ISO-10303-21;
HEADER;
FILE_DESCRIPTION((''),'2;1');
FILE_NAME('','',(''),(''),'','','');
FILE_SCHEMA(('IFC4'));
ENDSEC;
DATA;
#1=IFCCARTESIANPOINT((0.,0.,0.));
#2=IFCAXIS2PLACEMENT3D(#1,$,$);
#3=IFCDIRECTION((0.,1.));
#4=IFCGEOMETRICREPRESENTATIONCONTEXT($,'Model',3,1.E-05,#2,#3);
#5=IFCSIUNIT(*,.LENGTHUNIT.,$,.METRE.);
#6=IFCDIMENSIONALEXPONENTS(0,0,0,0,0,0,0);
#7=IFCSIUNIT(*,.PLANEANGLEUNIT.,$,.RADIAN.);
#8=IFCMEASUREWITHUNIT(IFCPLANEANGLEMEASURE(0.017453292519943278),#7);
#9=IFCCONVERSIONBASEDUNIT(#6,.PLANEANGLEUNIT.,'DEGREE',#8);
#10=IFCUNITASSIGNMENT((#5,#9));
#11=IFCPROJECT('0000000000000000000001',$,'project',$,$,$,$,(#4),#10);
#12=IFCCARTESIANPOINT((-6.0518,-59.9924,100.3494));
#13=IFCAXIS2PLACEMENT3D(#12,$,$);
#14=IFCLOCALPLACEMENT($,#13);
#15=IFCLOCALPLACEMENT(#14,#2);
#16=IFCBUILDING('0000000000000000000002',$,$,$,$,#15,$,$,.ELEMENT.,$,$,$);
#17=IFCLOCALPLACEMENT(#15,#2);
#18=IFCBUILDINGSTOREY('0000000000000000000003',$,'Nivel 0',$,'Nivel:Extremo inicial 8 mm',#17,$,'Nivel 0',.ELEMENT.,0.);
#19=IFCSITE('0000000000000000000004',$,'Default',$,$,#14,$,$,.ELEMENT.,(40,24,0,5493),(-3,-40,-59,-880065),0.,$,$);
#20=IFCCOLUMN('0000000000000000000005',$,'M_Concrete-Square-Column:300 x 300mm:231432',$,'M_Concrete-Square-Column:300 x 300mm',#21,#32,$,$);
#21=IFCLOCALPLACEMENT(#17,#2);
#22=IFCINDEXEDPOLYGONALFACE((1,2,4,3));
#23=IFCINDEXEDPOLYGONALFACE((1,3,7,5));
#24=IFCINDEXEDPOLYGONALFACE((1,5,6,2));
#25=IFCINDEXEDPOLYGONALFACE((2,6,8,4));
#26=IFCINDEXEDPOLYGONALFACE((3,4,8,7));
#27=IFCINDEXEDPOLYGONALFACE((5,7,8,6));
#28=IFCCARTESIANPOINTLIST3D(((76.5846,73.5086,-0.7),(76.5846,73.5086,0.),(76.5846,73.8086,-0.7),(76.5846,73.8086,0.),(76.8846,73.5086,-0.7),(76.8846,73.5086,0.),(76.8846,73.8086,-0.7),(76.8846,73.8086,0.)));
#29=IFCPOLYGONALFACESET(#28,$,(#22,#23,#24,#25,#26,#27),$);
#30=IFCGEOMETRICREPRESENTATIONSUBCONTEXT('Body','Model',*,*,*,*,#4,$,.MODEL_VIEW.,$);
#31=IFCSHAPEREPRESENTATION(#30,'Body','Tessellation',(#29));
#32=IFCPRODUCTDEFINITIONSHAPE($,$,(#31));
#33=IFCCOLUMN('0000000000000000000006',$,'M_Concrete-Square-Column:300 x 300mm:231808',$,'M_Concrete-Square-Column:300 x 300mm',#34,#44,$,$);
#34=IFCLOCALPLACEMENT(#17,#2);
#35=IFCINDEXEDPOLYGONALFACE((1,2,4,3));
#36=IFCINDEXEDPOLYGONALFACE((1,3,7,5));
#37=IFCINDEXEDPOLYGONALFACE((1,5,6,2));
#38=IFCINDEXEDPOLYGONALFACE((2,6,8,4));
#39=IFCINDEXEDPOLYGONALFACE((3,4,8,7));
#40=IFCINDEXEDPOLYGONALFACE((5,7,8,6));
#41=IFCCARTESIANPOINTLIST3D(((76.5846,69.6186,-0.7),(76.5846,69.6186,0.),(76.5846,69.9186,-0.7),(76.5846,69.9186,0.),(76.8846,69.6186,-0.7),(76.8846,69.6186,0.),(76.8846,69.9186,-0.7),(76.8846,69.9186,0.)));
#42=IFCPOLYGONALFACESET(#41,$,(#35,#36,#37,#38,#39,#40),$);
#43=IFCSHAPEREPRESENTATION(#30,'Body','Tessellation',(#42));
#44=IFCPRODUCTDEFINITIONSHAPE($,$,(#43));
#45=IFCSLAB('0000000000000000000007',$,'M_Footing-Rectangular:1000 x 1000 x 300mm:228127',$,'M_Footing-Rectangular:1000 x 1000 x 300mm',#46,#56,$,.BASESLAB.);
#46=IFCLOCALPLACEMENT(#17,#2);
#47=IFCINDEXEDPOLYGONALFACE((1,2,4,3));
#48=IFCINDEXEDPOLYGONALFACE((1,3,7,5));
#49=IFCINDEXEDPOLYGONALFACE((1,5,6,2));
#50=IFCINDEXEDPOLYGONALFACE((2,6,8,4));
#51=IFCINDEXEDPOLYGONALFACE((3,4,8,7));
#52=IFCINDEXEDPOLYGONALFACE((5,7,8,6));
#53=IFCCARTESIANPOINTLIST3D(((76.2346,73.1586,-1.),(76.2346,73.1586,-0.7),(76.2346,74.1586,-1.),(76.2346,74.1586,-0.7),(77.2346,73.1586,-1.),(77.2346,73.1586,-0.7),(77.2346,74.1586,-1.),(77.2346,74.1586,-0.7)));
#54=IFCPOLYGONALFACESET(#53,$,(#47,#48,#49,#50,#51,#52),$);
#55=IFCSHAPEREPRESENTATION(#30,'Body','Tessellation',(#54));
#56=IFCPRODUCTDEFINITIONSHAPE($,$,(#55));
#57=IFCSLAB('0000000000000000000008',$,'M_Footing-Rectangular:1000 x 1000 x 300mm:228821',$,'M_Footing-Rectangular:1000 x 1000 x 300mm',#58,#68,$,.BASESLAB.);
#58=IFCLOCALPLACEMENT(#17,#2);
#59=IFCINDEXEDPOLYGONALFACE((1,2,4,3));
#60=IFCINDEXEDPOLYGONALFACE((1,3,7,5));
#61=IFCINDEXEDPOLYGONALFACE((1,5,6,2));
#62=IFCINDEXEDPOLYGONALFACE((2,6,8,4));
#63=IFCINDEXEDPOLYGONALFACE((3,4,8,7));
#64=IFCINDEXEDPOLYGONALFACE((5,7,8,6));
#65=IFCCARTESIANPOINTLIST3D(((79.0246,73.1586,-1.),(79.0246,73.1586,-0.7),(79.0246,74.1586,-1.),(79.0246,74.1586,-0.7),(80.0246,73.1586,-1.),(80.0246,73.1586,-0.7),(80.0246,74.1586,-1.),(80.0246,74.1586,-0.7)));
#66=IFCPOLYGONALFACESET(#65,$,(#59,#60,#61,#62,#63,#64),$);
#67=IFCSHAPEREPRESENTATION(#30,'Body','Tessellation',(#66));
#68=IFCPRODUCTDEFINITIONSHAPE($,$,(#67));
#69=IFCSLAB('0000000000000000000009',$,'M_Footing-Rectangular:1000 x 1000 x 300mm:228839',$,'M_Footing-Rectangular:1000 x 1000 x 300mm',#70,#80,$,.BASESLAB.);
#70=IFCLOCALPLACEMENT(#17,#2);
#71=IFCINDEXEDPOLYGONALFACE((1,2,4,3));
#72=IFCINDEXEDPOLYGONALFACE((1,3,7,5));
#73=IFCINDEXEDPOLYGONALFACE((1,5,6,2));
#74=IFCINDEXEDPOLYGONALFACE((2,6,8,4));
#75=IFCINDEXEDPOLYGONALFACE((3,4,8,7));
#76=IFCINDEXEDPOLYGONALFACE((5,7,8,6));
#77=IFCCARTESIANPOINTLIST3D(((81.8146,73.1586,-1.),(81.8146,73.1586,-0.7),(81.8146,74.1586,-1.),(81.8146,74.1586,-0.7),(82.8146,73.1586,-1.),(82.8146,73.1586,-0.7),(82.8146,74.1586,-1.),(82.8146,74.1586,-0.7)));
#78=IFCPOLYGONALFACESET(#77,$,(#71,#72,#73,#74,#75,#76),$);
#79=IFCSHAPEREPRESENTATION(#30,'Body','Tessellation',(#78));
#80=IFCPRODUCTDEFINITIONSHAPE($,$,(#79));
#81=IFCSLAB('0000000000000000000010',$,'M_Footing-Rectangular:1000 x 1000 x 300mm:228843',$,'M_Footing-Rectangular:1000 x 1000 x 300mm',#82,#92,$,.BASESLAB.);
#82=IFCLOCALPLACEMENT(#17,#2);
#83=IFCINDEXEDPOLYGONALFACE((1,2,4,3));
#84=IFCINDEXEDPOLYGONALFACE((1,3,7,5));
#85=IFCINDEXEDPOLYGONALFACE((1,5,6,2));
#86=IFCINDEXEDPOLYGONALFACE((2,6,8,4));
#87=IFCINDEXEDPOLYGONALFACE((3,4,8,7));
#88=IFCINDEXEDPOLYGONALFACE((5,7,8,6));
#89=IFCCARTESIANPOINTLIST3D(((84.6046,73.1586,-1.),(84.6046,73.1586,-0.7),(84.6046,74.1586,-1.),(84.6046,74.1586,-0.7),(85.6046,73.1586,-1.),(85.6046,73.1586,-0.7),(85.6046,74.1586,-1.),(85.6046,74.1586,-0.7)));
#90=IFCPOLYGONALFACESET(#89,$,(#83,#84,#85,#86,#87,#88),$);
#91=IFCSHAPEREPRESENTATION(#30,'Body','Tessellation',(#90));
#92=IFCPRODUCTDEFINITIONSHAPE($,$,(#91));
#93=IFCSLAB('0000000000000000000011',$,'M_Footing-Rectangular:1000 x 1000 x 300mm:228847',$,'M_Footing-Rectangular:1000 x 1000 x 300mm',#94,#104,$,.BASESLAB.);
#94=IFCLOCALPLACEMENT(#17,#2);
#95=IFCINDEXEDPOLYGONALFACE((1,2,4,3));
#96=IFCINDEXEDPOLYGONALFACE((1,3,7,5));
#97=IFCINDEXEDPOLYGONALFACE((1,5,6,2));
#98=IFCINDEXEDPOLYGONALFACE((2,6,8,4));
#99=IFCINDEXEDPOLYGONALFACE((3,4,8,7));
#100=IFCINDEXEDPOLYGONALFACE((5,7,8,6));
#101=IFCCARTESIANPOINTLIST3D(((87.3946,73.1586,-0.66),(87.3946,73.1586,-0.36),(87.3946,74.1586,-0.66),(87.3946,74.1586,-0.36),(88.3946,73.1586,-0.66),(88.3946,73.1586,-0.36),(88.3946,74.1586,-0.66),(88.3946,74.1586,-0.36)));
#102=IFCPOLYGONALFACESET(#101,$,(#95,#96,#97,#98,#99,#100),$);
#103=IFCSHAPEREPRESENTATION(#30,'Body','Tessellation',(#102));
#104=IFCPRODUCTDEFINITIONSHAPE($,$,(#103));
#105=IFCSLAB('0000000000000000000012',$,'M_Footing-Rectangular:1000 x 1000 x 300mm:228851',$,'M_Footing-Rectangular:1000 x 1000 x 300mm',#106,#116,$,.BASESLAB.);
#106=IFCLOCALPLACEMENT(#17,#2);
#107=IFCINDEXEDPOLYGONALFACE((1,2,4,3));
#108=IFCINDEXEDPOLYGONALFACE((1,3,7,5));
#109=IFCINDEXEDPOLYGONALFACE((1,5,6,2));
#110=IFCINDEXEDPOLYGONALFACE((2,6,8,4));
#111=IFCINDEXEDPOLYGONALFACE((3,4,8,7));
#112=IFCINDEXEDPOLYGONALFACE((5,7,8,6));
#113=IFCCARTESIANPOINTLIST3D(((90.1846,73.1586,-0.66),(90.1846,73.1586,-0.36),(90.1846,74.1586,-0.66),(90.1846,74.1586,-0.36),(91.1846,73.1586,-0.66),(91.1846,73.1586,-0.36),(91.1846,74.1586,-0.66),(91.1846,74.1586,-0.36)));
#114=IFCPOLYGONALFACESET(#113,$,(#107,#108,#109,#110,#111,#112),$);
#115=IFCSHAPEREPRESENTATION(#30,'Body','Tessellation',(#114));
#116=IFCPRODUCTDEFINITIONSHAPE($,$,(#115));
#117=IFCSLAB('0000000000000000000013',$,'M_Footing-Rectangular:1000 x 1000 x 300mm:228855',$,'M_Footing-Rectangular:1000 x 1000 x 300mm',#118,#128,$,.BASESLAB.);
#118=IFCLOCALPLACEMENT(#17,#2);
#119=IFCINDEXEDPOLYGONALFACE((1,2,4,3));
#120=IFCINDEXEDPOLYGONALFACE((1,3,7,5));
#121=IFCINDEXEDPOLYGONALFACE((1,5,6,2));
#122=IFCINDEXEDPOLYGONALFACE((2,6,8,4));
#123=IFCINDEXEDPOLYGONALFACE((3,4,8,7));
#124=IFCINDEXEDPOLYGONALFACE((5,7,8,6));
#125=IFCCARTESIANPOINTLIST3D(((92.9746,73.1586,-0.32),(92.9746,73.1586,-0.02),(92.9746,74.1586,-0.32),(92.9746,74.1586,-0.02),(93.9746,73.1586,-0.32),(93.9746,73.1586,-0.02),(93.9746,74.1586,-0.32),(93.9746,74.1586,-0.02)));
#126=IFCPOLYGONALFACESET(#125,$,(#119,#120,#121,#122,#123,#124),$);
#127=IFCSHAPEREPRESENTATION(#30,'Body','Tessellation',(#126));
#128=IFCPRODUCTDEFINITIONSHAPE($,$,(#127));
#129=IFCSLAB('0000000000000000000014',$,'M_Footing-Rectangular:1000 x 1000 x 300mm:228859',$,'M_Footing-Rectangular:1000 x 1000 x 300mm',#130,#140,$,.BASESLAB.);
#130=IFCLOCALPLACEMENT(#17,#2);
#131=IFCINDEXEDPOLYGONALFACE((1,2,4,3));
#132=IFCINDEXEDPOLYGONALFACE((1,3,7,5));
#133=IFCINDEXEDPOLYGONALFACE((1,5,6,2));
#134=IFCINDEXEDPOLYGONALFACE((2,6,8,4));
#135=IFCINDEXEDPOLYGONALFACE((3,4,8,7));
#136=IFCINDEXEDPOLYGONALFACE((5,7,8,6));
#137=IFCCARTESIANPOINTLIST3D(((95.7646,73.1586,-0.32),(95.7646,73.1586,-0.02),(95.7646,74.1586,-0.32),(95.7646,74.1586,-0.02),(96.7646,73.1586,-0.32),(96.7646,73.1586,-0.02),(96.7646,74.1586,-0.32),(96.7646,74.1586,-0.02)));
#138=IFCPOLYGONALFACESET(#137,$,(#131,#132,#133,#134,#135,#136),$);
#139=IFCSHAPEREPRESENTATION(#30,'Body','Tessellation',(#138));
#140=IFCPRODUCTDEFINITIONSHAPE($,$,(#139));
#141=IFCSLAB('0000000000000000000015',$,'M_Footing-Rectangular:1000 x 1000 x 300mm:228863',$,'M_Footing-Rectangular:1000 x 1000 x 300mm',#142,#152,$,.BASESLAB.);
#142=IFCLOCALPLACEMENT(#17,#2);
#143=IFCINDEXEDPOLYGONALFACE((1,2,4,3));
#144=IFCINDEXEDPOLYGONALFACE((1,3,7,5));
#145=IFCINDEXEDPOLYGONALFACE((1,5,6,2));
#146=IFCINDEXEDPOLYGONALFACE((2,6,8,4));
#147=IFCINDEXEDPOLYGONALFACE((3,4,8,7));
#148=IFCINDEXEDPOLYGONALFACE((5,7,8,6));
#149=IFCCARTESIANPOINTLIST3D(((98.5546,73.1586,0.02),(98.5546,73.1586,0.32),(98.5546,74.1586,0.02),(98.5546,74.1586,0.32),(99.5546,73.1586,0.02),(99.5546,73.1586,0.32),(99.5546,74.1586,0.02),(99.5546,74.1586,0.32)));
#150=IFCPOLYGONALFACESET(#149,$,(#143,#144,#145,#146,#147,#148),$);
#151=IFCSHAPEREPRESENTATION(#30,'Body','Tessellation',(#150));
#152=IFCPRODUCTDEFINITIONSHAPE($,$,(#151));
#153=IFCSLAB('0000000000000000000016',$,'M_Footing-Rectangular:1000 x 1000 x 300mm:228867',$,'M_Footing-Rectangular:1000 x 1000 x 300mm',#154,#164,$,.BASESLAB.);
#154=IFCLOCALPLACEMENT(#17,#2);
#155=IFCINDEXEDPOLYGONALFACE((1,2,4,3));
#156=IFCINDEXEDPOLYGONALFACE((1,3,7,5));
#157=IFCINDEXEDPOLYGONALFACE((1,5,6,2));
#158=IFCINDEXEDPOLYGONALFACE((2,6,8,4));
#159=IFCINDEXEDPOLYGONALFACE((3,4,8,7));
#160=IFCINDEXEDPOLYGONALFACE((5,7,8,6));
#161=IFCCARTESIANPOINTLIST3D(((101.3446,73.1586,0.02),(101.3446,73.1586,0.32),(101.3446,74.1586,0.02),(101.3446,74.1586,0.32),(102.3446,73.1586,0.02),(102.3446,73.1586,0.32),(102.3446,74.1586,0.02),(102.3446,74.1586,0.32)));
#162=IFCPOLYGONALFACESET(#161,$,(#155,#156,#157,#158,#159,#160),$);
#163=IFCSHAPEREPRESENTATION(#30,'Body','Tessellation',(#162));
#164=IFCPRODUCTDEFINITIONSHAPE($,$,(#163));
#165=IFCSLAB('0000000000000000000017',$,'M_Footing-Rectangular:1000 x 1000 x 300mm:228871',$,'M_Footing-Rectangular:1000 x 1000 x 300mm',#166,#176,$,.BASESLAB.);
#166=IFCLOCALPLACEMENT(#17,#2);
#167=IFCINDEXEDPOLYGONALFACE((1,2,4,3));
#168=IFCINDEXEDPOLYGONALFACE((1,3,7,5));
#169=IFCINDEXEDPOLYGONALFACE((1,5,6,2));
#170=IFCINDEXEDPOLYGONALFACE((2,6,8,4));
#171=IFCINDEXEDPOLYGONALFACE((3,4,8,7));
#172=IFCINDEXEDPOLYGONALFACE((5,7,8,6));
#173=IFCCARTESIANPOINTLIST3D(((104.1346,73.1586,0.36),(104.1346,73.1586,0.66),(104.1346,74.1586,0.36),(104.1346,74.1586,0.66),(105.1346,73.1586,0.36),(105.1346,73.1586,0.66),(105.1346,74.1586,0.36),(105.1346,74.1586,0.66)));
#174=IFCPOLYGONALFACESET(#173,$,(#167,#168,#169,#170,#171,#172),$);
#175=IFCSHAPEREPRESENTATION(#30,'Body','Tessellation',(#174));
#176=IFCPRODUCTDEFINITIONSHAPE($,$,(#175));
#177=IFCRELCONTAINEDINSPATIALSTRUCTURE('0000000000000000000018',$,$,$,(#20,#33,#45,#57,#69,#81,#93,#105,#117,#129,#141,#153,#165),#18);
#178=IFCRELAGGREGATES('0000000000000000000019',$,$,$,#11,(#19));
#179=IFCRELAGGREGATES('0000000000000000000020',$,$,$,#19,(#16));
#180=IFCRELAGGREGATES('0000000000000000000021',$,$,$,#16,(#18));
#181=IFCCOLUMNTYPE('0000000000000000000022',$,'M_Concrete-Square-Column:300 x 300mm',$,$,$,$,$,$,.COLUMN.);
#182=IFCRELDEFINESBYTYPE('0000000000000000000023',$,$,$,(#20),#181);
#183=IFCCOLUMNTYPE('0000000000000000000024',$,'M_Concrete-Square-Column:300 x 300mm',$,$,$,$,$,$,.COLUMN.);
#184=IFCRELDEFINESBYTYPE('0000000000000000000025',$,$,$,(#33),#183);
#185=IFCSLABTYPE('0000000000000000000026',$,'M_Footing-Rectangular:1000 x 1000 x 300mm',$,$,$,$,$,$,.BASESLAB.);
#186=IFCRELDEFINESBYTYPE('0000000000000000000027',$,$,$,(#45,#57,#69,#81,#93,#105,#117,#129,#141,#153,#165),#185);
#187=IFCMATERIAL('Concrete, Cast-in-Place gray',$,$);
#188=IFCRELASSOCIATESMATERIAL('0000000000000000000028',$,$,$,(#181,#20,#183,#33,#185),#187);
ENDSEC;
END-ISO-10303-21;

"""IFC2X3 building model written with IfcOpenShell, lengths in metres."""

from ifc_helpers import new_model, entity, si_unit, converted_unit, direction, frame, frame_2d, origin, origin_2d_with_axis, place, context, subcontext, project, spatial, rectangle, extrude, source, transform, mapped, material, type_object, type_shapes, element, save


model = new_model("IFC2X3")

# Units and contexts
model_context = context("Model", 3, precision=1e-05, world=origin(), true_north=direction((0.0, 1.0)))
body_context = subcontext(model_context, "Body", "Model", "MODEL_VIEW")
ifc_project = project(units=[si_unit("LENGTHUNIT", "METRE"), converted_unit("PLANEANGLEUNIT", "DEGREE", entity("IfcPlaneAngleMeasure", 0.017453292519943278), si_unit("PLANEANGLEUNIT", "RADIAN"), dimensions=[0, 0, 0, 0, 0, 0, 0])], contexts=[model_context])

# Site, building, storey
site_placement = place(None, frame((-6.0518, -59.9924, 100.3494)))
site = spatial("IfcSite", under=ifc_project, at=site_placement, Name="Default", CompositionType="ELEMENT", RefLatitude=(40, 24, 0, 5493), RefLongitude=(-3, -40, -59, -880065), RefElevation=0.0)
building_placement = place(site_placement, origin())
building = spatial("IfcBuilding", under=site, at=building_placement, CompositionType="ELEMENT")
storey_placement = place(building_placement, origin())
storey = spatial("IfcBuildingStorey", under=building, at=storey_placement, Name="Nivel 0", ObjectType="Nivel:Extremo inicial 8 mm", LongName="Nivel 0", CompositionType="ELEMENT", Elevation=0.0)

# Columns
ifc_material = material(Name="Concrete, Cast-in-Place gray")
column_type_1 = type_object("IfcColumnType", Name="M_Concrete-Square-Column:300 x 300mm", PredefinedType="COLUMN", material=ifc_material)
shared_shape_1 = source(origin(), body_context, "Body", "SweptSolid", [
    extrude(rectangle(XDim=0.3, YDim=0.3, at=origin_2d_with_axis()), frame((76.7346, 73.6586, -0.7), z_axis=(0.0, 0.0, 1.0), x_axis=(-1.0, 0.0, 0.0)), (0.0, 0.0, 1.0), 0.7),
])
type_shapes(column_type_1, [shared_shape_1])
column_1_placement = place(storey_placement, origin())
element("IfcColumn", 1, at=column_1_placement, inside=storey, type_object=column_type_1, material=ifc_material, Name="M_Concrete-Square-Column:300 x 300mm:231432", ObjectType="M_Concrete-Square-Column:300 x 300mm", context=body_context, shape_type="MappedRepresentation", body=[
    mapped(shared_shape_1, transform((0.0, 0.0, 0.0), scale=1.0)),
])
column_type_2 = type_object("IfcColumnType", Name="M_Concrete-Square-Column:300 x 300mm", PredefinedType="COLUMN", material=ifc_material)
shared_shape_2 = source(origin(), body_context, "Body", "SweptSolid", [
    extrude(rectangle(XDim=0.3, YDim=0.3, at=origin_2d_with_axis()), frame((76.7346, 69.7686, -0.7), z_axis=(0.0, 0.0, 1.0), x_axis=(-1.0, 0.0, 0.0)), (0.0, 0.0, 1.0), 0.7),
])
type_shapes(column_type_2, [shared_shape_2])
column_2_placement = place(storey_placement, origin())
element("IfcColumn", 2, at=column_2_placement, inside=storey, type_object=column_type_2, material=ifc_material, Name="M_Concrete-Square-Column:300 x 300mm:231808", ObjectType="M_Concrete-Square-Column:300 x 300mm", context=body_context, shape_type="MappedRepresentation", body=[
    mapped(shared_shape_2, transform((0.0, 0.0, 0.0), scale=1.0)),
])

# Slabs
slab_type_1 = type_object("IfcSlabType", Name="M_Footing-Rectangular:1000 x 1000 x 300mm", PredefinedType="BASESLAB", material=ifc_material)
slab_1_placement = place(storey_placement, origin())
element("IfcSlab", 3, at=slab_1_placement, inside=storey, type_object=slab_type_1, Name="M_Footing-Rectangular:1000 x 1000 x 300mm:228127", ObjectType="M_Footing-Rectangular:1000 x 1000 x 300mm", PredefinedType="BASESLAB", context=body_context, shape_type="SweptSolid", body=[
    extrude(rectangle(XDim=1.0, YDim=1.0, at=frame_2d((0.0, 0.0), x_axis=(1.0, 0.0))), frame((76.7346, 73.6586, -1.0), z_axis=(0.0, 0.0, 1.0), x_axis=(-1.0, 0.0, 0.0)), (0.0, 0.0, 1.0), 0.3),
])
slab_2_placement = place(storey_placement, origin())
element("IfcSlab", 4, at=slab_2_placement, inside=storey, type_object=slab_type_1, Name="M_Footing-Rectangular:1000 x 1000 x 300mm:228821", ObjectType="M_Footing-Rectangular:1000 x 1000 x 300mm", PredefinedType="BASESLAB", context=body_context, shape_type="SweptSolid", body=[
    extrude(rectangle(XDim=1.0, YDim=1.0, at=frame_2d((0.0, 0.0), x_axis=(1.0, 0.0))), frame((79.5246, 73.6586, -1.0), z_axis=(0.0, 0.0, 1.0), x_axis=(-1.0, 0.0, 0.0)), (0.0, 0.0, 1.0), 0.3),
])
slab_3_placement = place(storey_placement, origin())
element("IfcSlab", 5, at=slab_3_placement, inside=storey, type_object=slab_type_1, Name="M_Footing-Rectangular:1000 x 1000 x 300mm:228839", ObjectType="M_Footing-Rectangular:1000 x 1000 x 300mm", PredefinedType="BASESLAB", context=body_context, shape_type="SweptSolid", body=[
    extrude(rectangle(XDim=1.0, YDim=1.0, at=frame_2d((0.0, 0.0), x_axis=(1.0, 0.0))), frame((82.3146, 73.6586, -1.0), z_axis=(0.0, 0.0, 1.0), x_axis=(-1.0, 0.0, 0.0)), (0.0, 0.0, 1.0), 0.3),
])
slab_4_placement = place(storey_placement, origin())
element("IfcSlab", 6, at=slab_4_placement, inside=storey, type_object=slab_type_1, Name="M_Footing-Rectangular:1000 x 1000 x 300mm:228843", ObjectType="M_Footing-Rectangular:1000 x 1000 x 300mm", PredefinedType="BASESLAB", context=body_context, shape_type="SweptSolid", body=[
    extrude(rectangle(XDim=1.0, YDim=1.0, at=frame_2d((0.0, 0.0), x_axis=(1.0, 0.0))), frame((85.1046, 73.6586, -1.0), z_axis=(0.0, 0.0, 1.0), x_axis=(-1.0, 0.0, 0.0)), (0.0, 0.0, 1.0), 0.3),
])
slab_5_placement = place(storey_placement, origin())
element("IfcSlab", 7, at=slab_5_placement, inside=storey, type_object=slab_type_1, Name="M_Footing-Rectangular:1000 x 1000 x 300mm:228847", ObjectType="M_Footing-Rectangular:1000 x 1000 x 300mm", PredefinedType="BASESLAB", context=body_context, shape_type="SweptSolid", body=[
    extrude(rectangle(XDim=1.0, YDim=1.0, at=frame_2d((0.0, 0.0), x_axis=(1.0, 0.0))), frame((87.8946, 73.6586, -0.66), z_axis=(0.0, 0.0, 1.0), x_axis=(-1.0, 0.0, 0.0)), (0.0, 0.0, 1.0), 0.3),
])
slab_6_placement = place(storey_placement, origin())
element("IfcSlab", 8, at=slab_6_placement, inside=storey, type_object=slab_type_1, Name="M_Footing-Rectangular:1000 x 1000 x 300mm:228851", ObjectType="M_Footing-Rectangular:1000 x 1000 x 300mm", PredefinedType="BASESLAB", context=body_context, shape_type="SweptSolid", body=[
    extrude(rectangle(XDim=1.0, YDim=1.0, at=frame_2d((0.0, 0.0), x_axis=(1.0, 0.0))), frame((90.6846, 73.6586, -0.66), z_axis=(0.0, 0.0, 1.0), x_axis=(-1.0, 0.0, 0.0)), (0.0, 0.0, 1.0), 0.3),
])
slab_7_placement = place(storey_placement, origin())
element("IfcSlab", 9, at=slab_7_placement, inside=storey, type_object=slab_type_1, Name="M_Footing-Rectangular:1000 x 1000 x 300mm:228855", ObjectType="M_Footing-Rectangular:1000 x 1000 x 300mm", PredefinedType="BASESLAB", context=body_context, shape_type="SweptSolid", body=[
    extrude(rectangle(XDim=1.0, YDim=1.0, at=frame_2d((0.0, 0.0), x_axis=(1.0, 0.0))), frame((93.4746, 73.6586, -0.32), z_axis=(0.0, 0.0, 1.0), x_axis=(-1.0, 0.0, 0.0)), (0.0, 0.0, 1.0), 0.3),
])
slab_8_placement = place(storey_placement, origin())
element("IfcSlab", 10, at=slab_8_placement, inside=storey, type_object=slab_type_1, Name="M_Footing-Rectangular:1000 x 1000 x 300mm:228859", ObjectType="M_Footing-Rectangular:1000 x 1000 x 300mm", PredefinedType="BASESLAB", context=body_context, shape_type="SweptSolid", body=[
    extrude(rectangle(XDim=1.0, YDim=1.0, at=frame_2d((0.0, 0.0), x_axis=(1.0, 0.0))), frame((96.2646, 73.6586, -0.32), z_axis=(0.0, 0.0, 1.0), x_axis=(-1.0, 0.0, 0.0)), (0.0, 0.0, 1.0), 0.3),
])
slab_9_placement = place(storey_placement, origin())
element("IfcSlab", 11, at=slab_9_placement, inside=storey, type_object=slab_type_1, Name="M_Footing-Rectangular:1000 x 1000 x 300mm:228863", ObjectType="M_Footing-Rectangular:1000 x 1000 x 300mm", PredefinedType="BASESLAB", context=body_context, shape_type="SweptSolid", body=[
    extrude(rectangle(XDim=1.0, YDim=1.0, at=frame_2d((0.0, 0.0), x_axis=(1.0, 0.0))), frame((99.0546, 73.6586, 0.02), z_axis=(0.0, 0.0, 1.0), x_axis=(-1.0, 0.0, 0.0)), (0.0, 0.0, 1.0), 0.3),
])
slab_10_placement = place(storey_placement, origin())
element("IfcSlab", 12, at=slab_10_placement, inside=storey, type_object=slab_type_1, Name="M_Footing-Rectangular:1000 x 1000 x 300mm:228867", ObjectType="M_Footing-Rectangular:1000 x 1000 x 300mm", PredefinedType="BASESLAB", context=body_context, shape_type="SweptSolid", body=[
    extrude(rectangle(XDim=1.0, YDim=1.0, at=frame_2d((0.0, 0.0), x_axis=(1.0, 0.0))), frame((101.8446, 73.6586, 0.02), z_axis=(0.0, 0.0, 1.0), x_axis=(-1.0, 0.0, 0.0)), (0.0, 0.0, 1.0), 0.3),
])
slab_11_placement = place(storey_placement, origin())
element("IfcSlab", 13, at=slab_11_placement, inside=storey, type_object=slab_type_1, Name="M_Footing-Rectangular:1000 x 1000 x 300mm:228871", ObjectType="M_Footing-Rectangular:1000 x 1000 x 300mm", PredefinedType="BASESLAB", context=body_context, shape_type="SweptSolid", body=[
    extrude(rectangle(XDim=1.0, YDim=1.0, at=frame_2d((0.0, 0.0), x_axis=(1.0, 0.0))), frame((104.6346, 73.6586, 0.36), z_axis=(0.0, 0.0, 1.0), x_axis=(-1.0, 0.0, 0.0)), (0.0, 0.0, 1.0), 0.3),
])

save(model, "model.ifc")
